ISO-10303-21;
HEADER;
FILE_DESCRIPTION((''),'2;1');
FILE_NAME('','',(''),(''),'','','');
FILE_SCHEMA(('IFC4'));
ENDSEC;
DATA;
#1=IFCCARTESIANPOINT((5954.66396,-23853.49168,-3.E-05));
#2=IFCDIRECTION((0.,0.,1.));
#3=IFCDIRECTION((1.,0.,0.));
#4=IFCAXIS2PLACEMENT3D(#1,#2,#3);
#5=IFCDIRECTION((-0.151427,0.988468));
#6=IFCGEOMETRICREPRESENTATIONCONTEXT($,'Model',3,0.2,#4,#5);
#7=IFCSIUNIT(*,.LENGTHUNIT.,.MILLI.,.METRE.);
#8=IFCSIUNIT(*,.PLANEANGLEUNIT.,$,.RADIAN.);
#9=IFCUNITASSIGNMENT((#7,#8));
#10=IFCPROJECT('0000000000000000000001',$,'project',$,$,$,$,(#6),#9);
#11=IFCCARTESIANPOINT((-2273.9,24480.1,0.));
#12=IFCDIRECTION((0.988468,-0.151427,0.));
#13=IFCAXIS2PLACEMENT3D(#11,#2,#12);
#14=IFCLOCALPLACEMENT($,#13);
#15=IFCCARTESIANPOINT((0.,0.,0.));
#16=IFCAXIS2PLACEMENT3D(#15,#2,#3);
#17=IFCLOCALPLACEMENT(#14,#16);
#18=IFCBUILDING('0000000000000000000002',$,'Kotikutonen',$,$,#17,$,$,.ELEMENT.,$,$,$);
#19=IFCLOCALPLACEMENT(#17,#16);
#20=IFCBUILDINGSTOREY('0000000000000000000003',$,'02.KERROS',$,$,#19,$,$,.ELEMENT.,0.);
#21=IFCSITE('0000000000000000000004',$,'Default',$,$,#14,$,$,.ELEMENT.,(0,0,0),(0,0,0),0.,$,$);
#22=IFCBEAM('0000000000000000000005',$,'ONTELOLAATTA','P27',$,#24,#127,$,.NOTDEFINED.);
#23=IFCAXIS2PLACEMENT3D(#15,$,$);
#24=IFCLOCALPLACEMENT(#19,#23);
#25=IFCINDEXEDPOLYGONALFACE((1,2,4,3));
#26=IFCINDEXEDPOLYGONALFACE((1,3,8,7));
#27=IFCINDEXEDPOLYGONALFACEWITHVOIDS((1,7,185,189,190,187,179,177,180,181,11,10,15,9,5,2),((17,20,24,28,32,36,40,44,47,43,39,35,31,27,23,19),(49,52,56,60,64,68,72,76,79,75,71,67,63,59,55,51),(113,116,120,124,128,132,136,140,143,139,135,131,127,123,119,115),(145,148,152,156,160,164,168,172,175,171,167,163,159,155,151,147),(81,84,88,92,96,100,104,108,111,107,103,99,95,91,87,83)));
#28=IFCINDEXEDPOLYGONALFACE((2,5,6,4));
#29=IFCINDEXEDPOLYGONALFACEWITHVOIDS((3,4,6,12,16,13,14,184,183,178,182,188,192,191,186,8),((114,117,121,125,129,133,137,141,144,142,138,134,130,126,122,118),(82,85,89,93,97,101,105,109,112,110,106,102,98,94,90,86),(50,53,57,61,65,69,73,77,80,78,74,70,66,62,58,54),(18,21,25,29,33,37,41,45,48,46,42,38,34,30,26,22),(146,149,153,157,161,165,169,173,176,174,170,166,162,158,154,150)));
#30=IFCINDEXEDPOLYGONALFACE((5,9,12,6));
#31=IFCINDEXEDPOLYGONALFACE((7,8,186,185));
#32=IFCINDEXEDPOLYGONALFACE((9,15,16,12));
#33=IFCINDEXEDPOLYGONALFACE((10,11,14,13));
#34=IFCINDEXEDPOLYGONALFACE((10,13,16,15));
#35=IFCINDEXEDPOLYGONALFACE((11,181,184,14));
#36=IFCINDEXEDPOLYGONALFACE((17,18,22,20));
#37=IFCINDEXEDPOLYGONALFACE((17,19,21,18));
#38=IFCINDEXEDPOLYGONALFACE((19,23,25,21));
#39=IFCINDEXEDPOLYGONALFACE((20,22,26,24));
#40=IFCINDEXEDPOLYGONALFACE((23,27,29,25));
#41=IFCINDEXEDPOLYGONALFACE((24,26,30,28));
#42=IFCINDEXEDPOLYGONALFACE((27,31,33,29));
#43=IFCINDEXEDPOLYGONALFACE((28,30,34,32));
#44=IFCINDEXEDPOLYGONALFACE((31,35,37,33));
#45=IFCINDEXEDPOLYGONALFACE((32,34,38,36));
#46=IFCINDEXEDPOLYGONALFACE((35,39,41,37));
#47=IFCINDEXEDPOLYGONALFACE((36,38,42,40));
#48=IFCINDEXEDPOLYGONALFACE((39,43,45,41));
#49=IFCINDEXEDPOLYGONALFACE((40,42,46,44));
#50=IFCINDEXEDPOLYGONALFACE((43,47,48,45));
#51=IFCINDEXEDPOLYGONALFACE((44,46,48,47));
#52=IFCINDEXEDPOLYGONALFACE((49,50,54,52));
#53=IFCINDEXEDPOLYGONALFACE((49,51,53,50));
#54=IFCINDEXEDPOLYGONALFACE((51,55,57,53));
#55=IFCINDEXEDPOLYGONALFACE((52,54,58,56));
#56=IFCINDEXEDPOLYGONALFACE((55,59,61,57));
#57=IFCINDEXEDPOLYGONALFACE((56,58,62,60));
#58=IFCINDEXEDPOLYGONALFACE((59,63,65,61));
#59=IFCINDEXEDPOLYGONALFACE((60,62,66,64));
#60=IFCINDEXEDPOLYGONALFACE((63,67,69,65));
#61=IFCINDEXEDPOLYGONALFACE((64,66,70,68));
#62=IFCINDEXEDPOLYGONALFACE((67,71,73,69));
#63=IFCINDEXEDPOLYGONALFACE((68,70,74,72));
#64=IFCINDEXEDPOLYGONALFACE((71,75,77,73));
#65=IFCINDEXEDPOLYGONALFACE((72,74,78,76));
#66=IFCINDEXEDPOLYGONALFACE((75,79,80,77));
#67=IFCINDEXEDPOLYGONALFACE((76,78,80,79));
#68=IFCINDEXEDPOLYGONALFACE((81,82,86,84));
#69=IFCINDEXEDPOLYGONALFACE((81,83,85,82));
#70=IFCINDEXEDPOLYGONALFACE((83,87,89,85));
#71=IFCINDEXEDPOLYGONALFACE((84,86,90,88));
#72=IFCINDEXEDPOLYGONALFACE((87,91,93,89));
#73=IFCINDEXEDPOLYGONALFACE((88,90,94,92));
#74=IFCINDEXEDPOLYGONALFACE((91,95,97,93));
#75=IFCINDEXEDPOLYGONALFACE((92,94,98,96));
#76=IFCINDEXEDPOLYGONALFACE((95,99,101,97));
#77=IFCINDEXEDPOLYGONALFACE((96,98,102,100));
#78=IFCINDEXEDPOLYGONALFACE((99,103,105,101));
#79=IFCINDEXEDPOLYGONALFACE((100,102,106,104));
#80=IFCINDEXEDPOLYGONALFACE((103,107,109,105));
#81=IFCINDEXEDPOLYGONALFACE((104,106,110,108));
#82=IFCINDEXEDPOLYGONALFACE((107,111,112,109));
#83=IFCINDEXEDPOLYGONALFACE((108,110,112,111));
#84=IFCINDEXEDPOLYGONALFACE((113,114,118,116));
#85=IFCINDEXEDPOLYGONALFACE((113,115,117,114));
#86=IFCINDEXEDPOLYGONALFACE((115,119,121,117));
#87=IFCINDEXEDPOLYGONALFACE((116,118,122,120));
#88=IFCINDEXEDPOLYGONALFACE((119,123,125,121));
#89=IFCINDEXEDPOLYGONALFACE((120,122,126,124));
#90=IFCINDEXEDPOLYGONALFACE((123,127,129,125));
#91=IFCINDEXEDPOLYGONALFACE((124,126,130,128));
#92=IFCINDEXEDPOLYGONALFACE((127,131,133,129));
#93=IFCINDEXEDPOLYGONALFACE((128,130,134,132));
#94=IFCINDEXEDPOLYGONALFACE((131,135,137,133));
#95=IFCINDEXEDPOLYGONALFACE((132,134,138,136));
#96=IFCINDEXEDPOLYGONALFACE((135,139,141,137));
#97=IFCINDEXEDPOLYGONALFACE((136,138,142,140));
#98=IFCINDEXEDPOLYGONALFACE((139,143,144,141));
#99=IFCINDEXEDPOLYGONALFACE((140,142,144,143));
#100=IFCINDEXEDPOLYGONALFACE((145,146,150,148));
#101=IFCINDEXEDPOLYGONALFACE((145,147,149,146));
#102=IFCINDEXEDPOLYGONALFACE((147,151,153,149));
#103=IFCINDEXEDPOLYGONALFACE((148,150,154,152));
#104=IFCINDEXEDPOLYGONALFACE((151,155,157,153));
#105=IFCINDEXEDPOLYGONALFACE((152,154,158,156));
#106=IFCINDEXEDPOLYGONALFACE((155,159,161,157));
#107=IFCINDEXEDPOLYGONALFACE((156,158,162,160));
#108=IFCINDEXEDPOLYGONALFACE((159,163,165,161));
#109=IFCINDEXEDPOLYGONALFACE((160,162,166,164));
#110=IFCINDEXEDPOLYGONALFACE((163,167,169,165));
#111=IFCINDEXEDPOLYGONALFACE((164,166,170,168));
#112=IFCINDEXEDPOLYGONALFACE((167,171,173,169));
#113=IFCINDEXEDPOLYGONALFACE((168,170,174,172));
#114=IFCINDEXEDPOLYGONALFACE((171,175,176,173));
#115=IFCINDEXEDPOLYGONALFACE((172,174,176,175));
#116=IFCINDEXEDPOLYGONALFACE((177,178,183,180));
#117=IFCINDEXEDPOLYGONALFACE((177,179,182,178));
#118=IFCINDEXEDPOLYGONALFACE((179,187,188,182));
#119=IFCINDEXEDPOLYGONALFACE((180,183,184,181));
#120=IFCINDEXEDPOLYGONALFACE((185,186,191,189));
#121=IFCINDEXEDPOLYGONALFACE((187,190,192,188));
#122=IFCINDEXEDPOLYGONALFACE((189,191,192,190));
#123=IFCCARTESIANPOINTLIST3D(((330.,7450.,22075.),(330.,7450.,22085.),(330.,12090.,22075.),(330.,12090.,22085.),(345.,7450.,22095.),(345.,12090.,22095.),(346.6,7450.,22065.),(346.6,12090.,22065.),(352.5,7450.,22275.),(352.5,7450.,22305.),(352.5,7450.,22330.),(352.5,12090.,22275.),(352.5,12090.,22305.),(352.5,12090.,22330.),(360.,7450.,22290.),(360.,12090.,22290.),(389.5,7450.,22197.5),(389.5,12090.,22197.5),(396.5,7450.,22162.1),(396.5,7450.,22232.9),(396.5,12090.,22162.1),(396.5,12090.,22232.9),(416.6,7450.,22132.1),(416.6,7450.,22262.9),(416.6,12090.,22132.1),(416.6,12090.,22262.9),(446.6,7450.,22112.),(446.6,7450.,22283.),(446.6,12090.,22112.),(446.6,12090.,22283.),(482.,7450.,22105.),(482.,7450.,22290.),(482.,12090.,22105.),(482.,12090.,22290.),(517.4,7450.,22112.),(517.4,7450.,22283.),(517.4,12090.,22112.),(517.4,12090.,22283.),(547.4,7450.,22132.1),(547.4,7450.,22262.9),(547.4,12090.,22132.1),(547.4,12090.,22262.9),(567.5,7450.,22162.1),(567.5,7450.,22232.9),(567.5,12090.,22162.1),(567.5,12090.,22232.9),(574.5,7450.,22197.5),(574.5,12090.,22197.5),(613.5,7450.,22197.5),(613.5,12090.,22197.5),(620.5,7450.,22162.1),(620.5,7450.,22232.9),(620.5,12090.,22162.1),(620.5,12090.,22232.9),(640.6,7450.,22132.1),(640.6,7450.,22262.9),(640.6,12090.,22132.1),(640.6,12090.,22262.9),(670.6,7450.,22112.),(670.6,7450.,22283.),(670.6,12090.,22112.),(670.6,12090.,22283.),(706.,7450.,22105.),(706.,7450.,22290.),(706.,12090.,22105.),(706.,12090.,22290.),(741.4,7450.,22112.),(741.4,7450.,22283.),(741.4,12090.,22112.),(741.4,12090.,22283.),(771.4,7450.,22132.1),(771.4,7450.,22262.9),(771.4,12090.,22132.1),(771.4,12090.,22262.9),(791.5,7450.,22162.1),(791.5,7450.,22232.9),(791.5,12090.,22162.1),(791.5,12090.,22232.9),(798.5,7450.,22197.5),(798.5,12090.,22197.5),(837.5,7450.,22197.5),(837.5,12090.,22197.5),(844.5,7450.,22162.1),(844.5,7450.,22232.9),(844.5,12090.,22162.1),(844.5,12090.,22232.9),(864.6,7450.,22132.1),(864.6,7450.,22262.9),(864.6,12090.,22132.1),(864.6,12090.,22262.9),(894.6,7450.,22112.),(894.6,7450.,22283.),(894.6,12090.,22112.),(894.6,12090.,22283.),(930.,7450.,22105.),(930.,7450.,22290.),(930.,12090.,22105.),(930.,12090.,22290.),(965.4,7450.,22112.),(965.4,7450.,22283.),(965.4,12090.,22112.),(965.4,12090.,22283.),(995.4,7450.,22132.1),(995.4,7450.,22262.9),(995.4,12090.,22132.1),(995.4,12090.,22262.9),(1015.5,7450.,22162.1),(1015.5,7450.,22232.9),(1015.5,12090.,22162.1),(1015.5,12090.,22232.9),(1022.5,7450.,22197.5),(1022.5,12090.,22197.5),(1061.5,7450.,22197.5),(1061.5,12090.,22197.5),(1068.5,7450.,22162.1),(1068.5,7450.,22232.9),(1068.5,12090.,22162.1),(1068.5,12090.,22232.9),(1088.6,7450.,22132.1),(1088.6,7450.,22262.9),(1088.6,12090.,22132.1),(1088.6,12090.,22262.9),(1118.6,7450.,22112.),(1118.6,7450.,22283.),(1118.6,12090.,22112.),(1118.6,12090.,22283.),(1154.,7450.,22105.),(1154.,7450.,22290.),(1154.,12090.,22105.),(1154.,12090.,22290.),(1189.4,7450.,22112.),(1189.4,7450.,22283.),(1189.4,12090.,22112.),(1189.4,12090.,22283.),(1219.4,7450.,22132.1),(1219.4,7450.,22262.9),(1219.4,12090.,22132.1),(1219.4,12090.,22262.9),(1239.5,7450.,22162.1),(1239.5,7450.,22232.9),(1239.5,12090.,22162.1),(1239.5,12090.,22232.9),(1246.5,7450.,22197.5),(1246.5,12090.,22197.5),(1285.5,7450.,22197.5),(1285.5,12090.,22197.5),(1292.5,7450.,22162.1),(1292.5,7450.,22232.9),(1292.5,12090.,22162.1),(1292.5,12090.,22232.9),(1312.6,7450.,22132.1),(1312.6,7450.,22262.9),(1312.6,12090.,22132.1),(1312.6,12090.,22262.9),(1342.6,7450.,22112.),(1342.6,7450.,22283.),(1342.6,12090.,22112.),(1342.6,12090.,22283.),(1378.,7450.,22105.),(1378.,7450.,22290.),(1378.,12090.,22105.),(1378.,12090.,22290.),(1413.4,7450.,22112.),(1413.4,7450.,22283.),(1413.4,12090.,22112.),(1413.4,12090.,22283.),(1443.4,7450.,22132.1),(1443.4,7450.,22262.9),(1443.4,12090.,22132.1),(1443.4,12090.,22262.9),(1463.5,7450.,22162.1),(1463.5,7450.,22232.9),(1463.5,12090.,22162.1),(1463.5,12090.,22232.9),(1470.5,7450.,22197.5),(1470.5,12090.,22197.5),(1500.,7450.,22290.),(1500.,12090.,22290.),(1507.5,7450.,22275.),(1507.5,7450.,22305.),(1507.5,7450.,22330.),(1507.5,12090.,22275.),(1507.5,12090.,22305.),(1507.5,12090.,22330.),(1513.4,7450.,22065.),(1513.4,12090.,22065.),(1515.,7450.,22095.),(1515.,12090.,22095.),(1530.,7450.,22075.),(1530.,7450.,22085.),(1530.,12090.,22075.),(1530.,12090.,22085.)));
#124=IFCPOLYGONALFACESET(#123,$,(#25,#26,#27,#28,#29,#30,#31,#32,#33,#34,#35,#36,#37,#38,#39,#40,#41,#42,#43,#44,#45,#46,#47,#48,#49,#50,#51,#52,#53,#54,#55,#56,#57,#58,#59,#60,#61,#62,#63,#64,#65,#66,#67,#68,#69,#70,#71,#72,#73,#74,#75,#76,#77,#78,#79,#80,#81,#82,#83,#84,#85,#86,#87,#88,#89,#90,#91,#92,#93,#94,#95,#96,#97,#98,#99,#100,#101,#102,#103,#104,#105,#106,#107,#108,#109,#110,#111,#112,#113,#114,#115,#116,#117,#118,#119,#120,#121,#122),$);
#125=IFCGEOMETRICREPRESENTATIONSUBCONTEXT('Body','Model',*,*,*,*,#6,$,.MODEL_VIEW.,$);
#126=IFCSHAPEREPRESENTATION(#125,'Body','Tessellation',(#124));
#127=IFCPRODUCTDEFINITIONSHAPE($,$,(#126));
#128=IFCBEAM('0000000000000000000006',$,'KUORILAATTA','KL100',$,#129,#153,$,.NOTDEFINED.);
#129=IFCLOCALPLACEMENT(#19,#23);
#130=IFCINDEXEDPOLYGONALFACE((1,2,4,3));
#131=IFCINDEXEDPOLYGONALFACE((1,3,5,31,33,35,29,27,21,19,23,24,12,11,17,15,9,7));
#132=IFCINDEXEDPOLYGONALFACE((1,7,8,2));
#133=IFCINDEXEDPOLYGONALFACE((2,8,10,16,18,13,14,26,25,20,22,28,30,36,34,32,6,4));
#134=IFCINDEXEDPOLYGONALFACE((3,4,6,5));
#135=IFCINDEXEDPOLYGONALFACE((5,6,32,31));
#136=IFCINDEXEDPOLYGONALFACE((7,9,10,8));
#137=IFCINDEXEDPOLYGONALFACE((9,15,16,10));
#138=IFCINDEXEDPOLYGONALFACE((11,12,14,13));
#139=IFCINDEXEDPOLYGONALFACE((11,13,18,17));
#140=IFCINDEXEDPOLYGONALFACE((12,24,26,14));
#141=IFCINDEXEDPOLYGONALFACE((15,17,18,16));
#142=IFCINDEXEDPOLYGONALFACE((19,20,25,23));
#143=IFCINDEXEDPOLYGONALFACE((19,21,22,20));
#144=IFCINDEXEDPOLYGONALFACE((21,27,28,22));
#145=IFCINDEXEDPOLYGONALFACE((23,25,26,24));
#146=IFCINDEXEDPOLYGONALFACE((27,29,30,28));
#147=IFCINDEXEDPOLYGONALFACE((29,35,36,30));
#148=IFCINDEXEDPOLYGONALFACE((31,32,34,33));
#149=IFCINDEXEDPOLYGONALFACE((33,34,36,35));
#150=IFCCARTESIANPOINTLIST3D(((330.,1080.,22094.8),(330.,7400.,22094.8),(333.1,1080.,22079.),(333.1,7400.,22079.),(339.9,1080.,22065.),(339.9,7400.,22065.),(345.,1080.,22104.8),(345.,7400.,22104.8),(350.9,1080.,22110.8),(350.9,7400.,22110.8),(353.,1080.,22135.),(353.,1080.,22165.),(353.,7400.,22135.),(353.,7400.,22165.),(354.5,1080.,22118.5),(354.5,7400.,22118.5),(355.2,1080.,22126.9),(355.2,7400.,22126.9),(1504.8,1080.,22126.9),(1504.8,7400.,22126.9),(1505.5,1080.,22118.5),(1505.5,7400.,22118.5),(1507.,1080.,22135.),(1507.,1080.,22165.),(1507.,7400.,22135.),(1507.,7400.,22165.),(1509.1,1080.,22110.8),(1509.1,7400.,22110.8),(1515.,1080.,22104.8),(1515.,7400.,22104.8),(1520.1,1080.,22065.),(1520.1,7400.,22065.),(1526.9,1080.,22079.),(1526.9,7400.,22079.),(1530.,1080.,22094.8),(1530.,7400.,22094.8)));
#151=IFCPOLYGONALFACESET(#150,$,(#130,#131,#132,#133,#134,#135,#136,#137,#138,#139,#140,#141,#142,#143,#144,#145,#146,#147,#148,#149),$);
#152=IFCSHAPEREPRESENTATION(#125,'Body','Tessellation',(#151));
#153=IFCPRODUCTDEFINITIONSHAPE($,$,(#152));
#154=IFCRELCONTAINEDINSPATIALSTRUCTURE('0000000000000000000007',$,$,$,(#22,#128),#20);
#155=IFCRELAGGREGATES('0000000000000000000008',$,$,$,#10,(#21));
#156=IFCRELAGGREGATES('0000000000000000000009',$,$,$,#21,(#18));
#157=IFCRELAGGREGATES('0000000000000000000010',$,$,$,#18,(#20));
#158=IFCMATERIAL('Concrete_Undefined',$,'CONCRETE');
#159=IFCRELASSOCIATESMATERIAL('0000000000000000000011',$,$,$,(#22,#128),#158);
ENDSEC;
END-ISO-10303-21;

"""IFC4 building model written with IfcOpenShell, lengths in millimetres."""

from ifc_helpers import new_model, si_unit, direction, frame, origin_with_axes, place, context, subcontext, project, spatial, line, indexed_curve, outline, extrude, material, element, save


model = new_model("IFC4")

# Units and contexts
model_context = context("Model", 3, precision=0.2, world=frame((5954.66396, -23853.49168, -3e-05), z_axis=(0.0, 0.0, 1.0), x_axis=(1.0, 0.0, 0.0)), true_north=direction((-0.151427, 0.988468)))
body_context = subcontext(model_context, "Body", "Model", "MODEL_VIEW")
ifc_project = project(units=[si_unit("LENGTHUNIT", "METRE", prefix="MILLI"), si_unit("PLANEANGLEUNIT", "RADIAN")], contexts=[model_context])

# Site, building, storey
site_placement = place(None, frame((-2273.9, 24480.1, 0.0), z_axis=(0.0, 0.0, 1.0), x_axis=(0.988468, -0.151427, 0.0)))
site = spatial("IfcSite", under=ifc_project, at=site_placement, Name="Default", CompositionType="ELEMENT", RefLatitude=(0, 0, 0), RefLongitude=(0, 0, 0), RefElevation=0.0)
building_placement = place(site_placement, origin_with_axes())
building = spatial("IfcBuilding", under=site, at=building_placement, Name="Kotikutonen", CompositionType="ELEMENT")
storey_placement = place(building_placement, origin_with_axes())
storey = spatial("IfcBuildingStorey", under=building, at=storey_placement, Name="02.KERROS", CompositionType="ELEMENT", Elevation=0.0)

# Beams
ifc_material_1 = material(Name="Concrete_Undefined", Category="CONCRETE")
beam_1_placement = place(storey_placement, frame((930.0, 12090.0, 22197.5), z_axis=(-1.0, 0.0, 0.0), x_axis=(0.0, -1.0, 0.0)))
element("IfcBeam", 1, at=beam_1_placement, inside=storey, material=ifc_material_1, Name="ONTELOLAATTA", Description="P27", PredefinedType="NOTDEFINED", context=body_context, shape_type="SolidModel", body=[
    extrude(outline(indexed_curve([(-600.0, -122.5), (-583.4, -132.5), (583.4, -132.5), (600.0, -122.5), (600.0, -112.5), (585.0, -102.5), (577.5, 77.5), (570.0, 92.5), (577.5, 107.5), (577.5, 132.5), (-577.5, 132.5), (-577.5, 107.5), (-570.0, 92.5), (-577.5, 77.5), (-585.0, -102.5), (-600.0, -112.5)], segments=[line(1, 2, 3, 4, 5, 6, 7, 8, 9, 10, 11, 12, 13, 14, 15, 16, 1)]), holes=[indexed_curve([(-448.0, -92.5), (-483.4, -85.5), (-513.4, -65.4), (-533.5, -35.4), (-540.5, 0.0), (-533.5, 35.4), (-513.4, 65.4), (-483.4, 85.5), (-448.0, 92.5), (-412.6, 85.5), (-382.6, 65.4), (-362.5, 35.4), (-355.5, 0.0), (-362.5, -35.4), (-382.6, -65.4), (-412.6, -85.5)], segments=[line(1, 2, 3, 4, 5, 6, 7, 8, 9, 10, 11, 12, 13, 14, 15, 16, 1)]), indexed_curve([(-224.0, -92.5), (-259.4, -85.5), (-289.4, -65.4), (-309.5, -35.4), (-316.5, 0.0), (-309.5, 35.4), (-289.4, 65.4), (-259.4, 85.5), (-224.0, 92.5), (-188.6, 85.5), (-158.6, 65.4), (-138.5, 35.4), (-131.5, 0.0), (-138.5, -35.4), (-158.6, -65.4), (-188.6, -85.5)], segments=[line(1, 2, 3, 4, 5, 6, 7, 8, 9, 10, 11, 12, 13, 14, 15, 16, 1)]), indexed_curve([(0.0, -92.5), (-35.4, -85.5), (-65.4, -65.4), (-85.5, -35.4), (-92.5, 0.0), (-85.5, 35.4), (-65.4, 65.4), (-35.4, 85.5), (0.0, 92.5), (35.4, 85.5), (65.4, 65.4), (85.5, 35.4), (92.5, 0.0), (85.5, -35.4), (65.4, -65.4), (35.4, -85.5)], segments=[line(1, 2, 3, 4, 5, 6, 7, 8, 9, 10, 11, 12, 13, 14, 15, 16, 1)]), indexed_curve([(224.0, -92.5), (188.6, -85.5), (158.6, -65.4), (138.5, -35.4), (131.5, 0.0), (138.5, 35.4), (158.6, 65.4), (188.6, 85.5), (224.0, 92.5), (259.4, 85.5), (289.4, 65.4), (309.5, 35.4), (316.5, 0.0), (309.5, -35.4), (289.4, -65.4), (259.4, -85.5)], segments=[line(1, 2, 3, 4, 5, 6, 7, 8, 9, 10, 11, 12, 13, 14, 15, 16, 1)]), indexed_curve([(448.0, -92.5), (412.6, -85.5), (382.6, -65.4), (362.5, -35.4), (355.5, 0.0), (362.5, 35.4), (382.6, 65.4), (412.6, 85.5), (448.0, 92.5), (483.4, 85.5), (513.4, 65.4), (533.5, 35.4), (540.5, 0.0), (533.5, -35.4), (513.4, -65.4), (483.4, -85.5)], segments=[line(1, 2, 3, 4, 5, 6, 7, 8, 9, 10, 11, 12, 13, 14, 15, 16, 1)])]), frame((0.0, 0.0, 0.0), z_axis=(-1.0, 0.0, 0.0), x_axis=(0.0, 0.0, 1.0)), (0.0, 0.0, -1.0), 4640.0),
])
beam_2_placement = place(storey_placement, frame((930.0, 7400.0, 22115.0), z_axis=(-1.0, 0.0, 0.0), x_axis=(0.0, -1.0, 0.0)))
element("IfcBeam", 2, at=beam_2_placement, inside=storey, material=ifc_material_1, Name="KUORILAATTA", Description="KL100", PredefinedType="NOTDEFINED", context=body_context, shape_type="SolidModel", body=[
    extrude(outline(indexed_curve([(-596.9, -36.0), (-590.1, -50.0), (590.1, -50.0), (596.9, -36.0), (600.0, -20.2), (585.0, -10.2), (579.1, -4.2), (575.5, 3.5), (574.8, 11.9), (577.0, 20.0), (577.0, 50.0), (-577.0, 50.0), (-577.0, 20.0), (-574.8, 11.9), (-575.5, 3.5), (-579.1, -4.2), (-585.0, -10.2), (-600.0, -20.2)], segments=[line(1, 2, 3, 4, 5, 6, 7, 8, 9, 10, 11, 12, 13, 14, 15, 16, 17, 18, 1)])), frame((0.0, 0.0, 0.0), z_axis=(-1.0, 0.0, 0.0), x_axis=(0.0, 0.0, 1.0)), (0.0, 0.0, -1.0), 6320.0),
])

save(model, "model.ifc")
